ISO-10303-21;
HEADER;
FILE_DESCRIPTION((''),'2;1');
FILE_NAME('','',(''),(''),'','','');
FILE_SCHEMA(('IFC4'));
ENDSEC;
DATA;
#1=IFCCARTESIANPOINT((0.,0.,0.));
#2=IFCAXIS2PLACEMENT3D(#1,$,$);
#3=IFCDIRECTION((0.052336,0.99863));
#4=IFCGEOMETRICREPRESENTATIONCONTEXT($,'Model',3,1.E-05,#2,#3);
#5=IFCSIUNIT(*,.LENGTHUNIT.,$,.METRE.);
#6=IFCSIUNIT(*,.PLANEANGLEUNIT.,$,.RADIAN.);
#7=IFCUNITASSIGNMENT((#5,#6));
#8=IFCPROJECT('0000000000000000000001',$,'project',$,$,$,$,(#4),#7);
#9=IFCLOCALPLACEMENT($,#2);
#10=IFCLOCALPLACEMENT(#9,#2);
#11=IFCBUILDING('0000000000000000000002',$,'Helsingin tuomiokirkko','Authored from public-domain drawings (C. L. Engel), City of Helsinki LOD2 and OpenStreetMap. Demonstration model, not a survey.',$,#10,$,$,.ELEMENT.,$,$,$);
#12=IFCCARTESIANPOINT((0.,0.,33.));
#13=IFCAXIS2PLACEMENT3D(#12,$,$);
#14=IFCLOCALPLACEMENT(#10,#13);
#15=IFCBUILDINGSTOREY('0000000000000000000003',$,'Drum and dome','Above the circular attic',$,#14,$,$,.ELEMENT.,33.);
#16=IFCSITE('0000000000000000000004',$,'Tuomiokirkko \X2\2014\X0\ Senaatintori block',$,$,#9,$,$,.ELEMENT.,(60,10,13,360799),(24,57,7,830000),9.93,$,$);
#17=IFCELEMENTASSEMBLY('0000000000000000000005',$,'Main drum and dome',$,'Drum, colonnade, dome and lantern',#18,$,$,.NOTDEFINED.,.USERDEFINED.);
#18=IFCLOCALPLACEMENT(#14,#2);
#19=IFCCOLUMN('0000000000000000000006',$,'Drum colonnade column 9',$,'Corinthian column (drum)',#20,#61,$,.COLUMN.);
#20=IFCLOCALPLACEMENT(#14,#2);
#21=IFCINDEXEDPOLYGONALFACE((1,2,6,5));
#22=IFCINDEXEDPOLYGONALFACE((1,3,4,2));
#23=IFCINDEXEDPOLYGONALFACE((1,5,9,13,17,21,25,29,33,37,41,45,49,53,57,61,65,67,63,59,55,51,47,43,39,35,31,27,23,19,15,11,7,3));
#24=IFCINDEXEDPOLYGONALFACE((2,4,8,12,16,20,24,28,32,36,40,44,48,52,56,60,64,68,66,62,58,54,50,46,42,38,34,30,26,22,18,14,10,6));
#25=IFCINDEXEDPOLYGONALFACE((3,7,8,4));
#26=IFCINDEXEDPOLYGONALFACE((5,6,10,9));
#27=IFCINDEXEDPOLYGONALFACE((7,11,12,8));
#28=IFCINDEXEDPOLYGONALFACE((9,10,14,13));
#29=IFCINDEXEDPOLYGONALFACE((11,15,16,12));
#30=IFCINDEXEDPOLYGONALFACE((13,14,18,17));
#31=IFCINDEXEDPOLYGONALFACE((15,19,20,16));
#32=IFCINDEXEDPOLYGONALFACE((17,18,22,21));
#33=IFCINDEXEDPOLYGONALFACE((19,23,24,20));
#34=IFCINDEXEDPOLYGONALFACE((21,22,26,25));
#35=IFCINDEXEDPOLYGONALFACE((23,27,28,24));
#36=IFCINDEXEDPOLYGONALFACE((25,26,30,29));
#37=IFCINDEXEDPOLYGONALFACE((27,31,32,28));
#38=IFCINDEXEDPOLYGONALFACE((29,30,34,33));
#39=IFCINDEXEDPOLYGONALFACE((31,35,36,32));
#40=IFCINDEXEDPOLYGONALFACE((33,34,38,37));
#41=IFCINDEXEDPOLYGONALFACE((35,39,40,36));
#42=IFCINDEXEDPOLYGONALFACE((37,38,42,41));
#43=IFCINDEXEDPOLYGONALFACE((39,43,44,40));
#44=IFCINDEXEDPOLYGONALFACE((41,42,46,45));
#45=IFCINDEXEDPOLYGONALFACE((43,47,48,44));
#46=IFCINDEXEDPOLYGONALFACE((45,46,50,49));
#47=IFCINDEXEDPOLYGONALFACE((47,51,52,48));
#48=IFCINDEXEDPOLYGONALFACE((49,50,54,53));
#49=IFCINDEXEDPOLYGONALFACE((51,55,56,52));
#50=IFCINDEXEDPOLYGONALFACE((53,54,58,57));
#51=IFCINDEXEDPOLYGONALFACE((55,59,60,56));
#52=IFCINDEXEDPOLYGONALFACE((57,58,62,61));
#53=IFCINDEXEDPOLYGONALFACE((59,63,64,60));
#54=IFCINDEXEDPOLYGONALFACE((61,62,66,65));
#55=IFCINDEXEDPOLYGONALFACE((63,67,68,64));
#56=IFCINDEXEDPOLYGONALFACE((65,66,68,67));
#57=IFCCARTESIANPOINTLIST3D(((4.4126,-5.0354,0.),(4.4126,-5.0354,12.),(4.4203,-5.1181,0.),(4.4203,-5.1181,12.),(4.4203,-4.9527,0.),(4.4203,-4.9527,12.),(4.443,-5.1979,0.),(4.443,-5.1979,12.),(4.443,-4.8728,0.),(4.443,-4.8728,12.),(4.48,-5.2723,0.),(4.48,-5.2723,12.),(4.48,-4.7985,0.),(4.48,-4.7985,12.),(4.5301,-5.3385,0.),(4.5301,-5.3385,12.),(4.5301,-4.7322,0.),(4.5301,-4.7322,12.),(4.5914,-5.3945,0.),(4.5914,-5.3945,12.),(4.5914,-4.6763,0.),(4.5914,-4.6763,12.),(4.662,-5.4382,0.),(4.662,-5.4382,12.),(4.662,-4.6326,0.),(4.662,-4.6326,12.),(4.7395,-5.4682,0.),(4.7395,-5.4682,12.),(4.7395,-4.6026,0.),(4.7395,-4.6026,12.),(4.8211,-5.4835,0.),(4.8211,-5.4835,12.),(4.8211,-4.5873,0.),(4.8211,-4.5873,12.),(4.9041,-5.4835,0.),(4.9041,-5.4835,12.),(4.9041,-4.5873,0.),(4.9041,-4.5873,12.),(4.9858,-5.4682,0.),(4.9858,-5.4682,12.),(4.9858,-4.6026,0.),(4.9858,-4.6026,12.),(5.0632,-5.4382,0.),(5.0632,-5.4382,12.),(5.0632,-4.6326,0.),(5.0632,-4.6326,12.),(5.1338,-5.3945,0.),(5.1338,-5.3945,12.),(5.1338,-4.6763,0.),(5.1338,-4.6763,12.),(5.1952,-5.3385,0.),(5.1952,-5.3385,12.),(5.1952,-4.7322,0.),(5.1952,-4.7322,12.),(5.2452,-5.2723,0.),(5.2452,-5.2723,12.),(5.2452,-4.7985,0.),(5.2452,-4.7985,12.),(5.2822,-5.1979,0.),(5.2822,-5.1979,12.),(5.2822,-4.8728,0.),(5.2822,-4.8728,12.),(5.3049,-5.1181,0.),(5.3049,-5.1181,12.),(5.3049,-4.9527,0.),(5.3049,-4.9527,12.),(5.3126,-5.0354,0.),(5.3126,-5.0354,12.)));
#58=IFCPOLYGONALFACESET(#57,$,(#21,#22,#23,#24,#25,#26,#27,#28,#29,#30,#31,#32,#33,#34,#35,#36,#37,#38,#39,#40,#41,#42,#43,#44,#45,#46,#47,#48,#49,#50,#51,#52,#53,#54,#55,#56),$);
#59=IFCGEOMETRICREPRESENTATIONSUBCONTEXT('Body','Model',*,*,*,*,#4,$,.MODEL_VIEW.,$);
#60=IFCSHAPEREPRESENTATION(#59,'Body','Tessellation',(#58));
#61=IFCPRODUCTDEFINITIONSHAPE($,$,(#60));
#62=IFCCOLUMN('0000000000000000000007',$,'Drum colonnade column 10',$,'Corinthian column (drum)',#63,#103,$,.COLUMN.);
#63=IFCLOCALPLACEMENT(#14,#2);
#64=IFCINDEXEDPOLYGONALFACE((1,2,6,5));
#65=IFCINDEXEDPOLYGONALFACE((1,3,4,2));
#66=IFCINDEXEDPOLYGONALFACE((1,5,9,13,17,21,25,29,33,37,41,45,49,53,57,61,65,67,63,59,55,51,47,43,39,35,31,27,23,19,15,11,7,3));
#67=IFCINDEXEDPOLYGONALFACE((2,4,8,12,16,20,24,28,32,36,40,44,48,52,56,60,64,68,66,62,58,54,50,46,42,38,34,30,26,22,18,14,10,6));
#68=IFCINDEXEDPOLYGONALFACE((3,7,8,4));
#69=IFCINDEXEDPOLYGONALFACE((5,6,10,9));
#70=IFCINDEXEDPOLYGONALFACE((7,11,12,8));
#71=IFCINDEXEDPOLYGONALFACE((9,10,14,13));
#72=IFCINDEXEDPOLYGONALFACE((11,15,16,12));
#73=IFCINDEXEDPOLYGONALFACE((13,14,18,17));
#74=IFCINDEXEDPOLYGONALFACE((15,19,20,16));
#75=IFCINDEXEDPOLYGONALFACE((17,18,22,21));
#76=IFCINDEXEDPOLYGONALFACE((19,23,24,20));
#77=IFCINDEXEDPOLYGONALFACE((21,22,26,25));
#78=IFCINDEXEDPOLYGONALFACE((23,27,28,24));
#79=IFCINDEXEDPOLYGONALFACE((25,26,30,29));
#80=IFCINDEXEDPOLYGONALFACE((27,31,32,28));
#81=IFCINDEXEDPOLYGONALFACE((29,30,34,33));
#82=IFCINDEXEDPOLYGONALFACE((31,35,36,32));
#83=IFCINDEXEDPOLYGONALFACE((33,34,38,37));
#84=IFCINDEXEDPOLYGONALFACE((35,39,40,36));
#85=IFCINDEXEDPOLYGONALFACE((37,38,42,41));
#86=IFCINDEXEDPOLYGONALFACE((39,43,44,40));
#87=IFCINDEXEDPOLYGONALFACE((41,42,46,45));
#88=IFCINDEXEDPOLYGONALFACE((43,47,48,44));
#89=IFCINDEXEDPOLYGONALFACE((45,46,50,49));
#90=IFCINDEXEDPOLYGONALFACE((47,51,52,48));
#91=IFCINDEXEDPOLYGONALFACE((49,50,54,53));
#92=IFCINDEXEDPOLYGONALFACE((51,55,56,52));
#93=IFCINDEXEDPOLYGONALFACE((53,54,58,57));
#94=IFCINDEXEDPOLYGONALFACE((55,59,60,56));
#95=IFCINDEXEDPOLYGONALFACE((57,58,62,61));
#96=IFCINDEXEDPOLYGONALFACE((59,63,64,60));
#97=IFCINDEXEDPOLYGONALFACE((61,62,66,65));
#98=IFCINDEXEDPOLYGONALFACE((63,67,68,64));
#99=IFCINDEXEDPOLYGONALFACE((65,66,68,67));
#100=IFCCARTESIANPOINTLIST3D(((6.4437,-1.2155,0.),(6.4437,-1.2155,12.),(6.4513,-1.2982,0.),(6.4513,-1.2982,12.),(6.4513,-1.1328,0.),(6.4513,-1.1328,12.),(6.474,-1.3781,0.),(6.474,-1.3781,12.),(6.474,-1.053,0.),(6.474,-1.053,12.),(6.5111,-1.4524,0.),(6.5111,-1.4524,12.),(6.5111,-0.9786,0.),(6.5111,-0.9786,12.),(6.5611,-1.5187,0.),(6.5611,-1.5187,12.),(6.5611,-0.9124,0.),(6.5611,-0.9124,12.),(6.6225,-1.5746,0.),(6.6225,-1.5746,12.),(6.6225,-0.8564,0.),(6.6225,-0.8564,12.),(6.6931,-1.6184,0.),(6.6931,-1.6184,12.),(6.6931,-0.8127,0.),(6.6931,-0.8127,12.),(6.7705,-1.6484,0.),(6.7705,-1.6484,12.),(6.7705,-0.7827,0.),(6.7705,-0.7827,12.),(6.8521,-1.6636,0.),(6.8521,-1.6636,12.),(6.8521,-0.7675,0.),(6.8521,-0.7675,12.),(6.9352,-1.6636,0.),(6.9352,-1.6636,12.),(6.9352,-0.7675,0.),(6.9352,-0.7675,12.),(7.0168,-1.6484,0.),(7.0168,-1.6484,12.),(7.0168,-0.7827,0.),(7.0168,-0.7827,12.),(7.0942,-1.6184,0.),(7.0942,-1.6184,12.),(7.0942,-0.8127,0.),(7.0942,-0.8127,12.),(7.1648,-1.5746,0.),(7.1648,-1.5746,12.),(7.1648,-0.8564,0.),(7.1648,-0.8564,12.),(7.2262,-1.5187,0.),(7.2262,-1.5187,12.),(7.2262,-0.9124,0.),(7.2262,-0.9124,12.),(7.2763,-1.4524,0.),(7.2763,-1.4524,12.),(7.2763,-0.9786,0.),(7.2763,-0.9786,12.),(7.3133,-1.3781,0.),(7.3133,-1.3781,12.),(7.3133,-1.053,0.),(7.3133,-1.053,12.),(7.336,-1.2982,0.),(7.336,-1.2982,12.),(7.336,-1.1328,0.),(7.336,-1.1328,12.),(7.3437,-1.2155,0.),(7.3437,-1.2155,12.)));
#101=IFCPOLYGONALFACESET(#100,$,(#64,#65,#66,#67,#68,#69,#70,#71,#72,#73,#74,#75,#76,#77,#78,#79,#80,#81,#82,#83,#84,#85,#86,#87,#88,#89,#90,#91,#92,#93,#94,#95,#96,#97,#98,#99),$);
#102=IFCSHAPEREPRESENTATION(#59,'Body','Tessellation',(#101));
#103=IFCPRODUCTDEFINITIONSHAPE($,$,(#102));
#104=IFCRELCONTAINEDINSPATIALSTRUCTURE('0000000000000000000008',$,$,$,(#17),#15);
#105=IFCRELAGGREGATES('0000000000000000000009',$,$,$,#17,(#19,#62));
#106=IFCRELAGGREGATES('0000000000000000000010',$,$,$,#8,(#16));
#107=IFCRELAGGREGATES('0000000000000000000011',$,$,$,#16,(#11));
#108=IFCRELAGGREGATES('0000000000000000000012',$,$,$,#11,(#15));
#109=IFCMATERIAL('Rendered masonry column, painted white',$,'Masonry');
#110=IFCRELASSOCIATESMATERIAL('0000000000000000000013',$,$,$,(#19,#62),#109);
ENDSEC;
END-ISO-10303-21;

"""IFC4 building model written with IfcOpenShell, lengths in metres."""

from ifc_helpers import new_model, si_unit, direction, frame, origin, origin_2d_with_axis, place, context, subcontext, project, spatial, circle, extrude, material, element, aggregate, save


model = new_model("IFC4")

# Units and contexts
model_context = context("Model", 3, precision=1e-05, world=origin(), true_north=direction((0.052336, 0.99863)))
body_context = subcontext(model_context, "Body", "Model", "MODEL_VIEW")
ifc_project = project(units=[si_unit("LENGTHUNIT", "METRE"), si_unit("PLANEANGLEUNIT", "RADIAN")], contexts=[model_context])

# Site, building, storey
site_placement = place(None, origin())
site = spatial("IfcSite", under=ifc_project, at=site_placement, Name="Tuomiokirkko — Senaatintori block", CompositionType="ELEMENT", RefLatitude=(60, 10, 13, 360799), RefLongitude=(24, 57, 7, 830000), RefElevation=9.93)
building_placement = place(site_placement, origin())
building = spatial("IfcBuilding", under=site, at=building_placement, Name="Helsingin tuomiokirkko", Description="Authored from public-domain drawings (C. L. Engel), City of Helsinki LOD2 and OpenStreetMap. Demonstration model, not a survey.", CompositionType="ELEMENT")
storey_placement = place(building_placement, frame((0.0, 0.0, 33.0)))
storey = spatial("IfcBuildingStorey", under=building, at=storey_placement, Name="Drum and dome", Description="Above the circular attic", CompositionType="ELEMENT", Elevation=33.0)

# Element assembly, columns
assembly_placement = place(building_placement, origin())
assembly = element("IfcElementAssembly", 1, at=assembly_placement, inside=storey, Name="Main drum and dome", ObjectType="Drum, colonnade, dome and lantern", AssemblyPlace="NOTDEFINED", PredefinedType="USERDEFINED")
ifc_material_1 = material(Name="Rendered masonry column, painted white", Category="Masonry")
column_1_placement = place(building_placement, origin())
column_1 = element("IfcColumn", 2, at=column_1_placement, material=ifc_material_1, Name="Drum colonnade column 9", ObjectType="Corinthian column (drum)", PredefinedType="COLUMN", context=body_context, shape_type="SweptSolid", body=[
    extrude(circle(Radius=0.45, at=origin_2d_with_axis()), frame((4.8626, -5.0354, 33.0)), (0.0, 0.0, 1.0), 12.0),
])
column_2_placement = place(building_placement, origin())
column_2 = element("IfcColumn", 3, at=column_2_placement, material=ifc_material_1, Name="Drum colonnade column 10", ObjectType="Corinthian column (drum)", PredefinedType="COLUMN", context=body_context, shape_type="SweptSolid", body=[
    extrude(circle(Radius=0.45, at=origin_2d_with_axis()), frame((6.8937, -1.2155, 33.0)), (0.0, 0.0, 1.0), 12.0),
])
aggregate(assembly, [column_1, column_2])

save(model, "model.ifc")
